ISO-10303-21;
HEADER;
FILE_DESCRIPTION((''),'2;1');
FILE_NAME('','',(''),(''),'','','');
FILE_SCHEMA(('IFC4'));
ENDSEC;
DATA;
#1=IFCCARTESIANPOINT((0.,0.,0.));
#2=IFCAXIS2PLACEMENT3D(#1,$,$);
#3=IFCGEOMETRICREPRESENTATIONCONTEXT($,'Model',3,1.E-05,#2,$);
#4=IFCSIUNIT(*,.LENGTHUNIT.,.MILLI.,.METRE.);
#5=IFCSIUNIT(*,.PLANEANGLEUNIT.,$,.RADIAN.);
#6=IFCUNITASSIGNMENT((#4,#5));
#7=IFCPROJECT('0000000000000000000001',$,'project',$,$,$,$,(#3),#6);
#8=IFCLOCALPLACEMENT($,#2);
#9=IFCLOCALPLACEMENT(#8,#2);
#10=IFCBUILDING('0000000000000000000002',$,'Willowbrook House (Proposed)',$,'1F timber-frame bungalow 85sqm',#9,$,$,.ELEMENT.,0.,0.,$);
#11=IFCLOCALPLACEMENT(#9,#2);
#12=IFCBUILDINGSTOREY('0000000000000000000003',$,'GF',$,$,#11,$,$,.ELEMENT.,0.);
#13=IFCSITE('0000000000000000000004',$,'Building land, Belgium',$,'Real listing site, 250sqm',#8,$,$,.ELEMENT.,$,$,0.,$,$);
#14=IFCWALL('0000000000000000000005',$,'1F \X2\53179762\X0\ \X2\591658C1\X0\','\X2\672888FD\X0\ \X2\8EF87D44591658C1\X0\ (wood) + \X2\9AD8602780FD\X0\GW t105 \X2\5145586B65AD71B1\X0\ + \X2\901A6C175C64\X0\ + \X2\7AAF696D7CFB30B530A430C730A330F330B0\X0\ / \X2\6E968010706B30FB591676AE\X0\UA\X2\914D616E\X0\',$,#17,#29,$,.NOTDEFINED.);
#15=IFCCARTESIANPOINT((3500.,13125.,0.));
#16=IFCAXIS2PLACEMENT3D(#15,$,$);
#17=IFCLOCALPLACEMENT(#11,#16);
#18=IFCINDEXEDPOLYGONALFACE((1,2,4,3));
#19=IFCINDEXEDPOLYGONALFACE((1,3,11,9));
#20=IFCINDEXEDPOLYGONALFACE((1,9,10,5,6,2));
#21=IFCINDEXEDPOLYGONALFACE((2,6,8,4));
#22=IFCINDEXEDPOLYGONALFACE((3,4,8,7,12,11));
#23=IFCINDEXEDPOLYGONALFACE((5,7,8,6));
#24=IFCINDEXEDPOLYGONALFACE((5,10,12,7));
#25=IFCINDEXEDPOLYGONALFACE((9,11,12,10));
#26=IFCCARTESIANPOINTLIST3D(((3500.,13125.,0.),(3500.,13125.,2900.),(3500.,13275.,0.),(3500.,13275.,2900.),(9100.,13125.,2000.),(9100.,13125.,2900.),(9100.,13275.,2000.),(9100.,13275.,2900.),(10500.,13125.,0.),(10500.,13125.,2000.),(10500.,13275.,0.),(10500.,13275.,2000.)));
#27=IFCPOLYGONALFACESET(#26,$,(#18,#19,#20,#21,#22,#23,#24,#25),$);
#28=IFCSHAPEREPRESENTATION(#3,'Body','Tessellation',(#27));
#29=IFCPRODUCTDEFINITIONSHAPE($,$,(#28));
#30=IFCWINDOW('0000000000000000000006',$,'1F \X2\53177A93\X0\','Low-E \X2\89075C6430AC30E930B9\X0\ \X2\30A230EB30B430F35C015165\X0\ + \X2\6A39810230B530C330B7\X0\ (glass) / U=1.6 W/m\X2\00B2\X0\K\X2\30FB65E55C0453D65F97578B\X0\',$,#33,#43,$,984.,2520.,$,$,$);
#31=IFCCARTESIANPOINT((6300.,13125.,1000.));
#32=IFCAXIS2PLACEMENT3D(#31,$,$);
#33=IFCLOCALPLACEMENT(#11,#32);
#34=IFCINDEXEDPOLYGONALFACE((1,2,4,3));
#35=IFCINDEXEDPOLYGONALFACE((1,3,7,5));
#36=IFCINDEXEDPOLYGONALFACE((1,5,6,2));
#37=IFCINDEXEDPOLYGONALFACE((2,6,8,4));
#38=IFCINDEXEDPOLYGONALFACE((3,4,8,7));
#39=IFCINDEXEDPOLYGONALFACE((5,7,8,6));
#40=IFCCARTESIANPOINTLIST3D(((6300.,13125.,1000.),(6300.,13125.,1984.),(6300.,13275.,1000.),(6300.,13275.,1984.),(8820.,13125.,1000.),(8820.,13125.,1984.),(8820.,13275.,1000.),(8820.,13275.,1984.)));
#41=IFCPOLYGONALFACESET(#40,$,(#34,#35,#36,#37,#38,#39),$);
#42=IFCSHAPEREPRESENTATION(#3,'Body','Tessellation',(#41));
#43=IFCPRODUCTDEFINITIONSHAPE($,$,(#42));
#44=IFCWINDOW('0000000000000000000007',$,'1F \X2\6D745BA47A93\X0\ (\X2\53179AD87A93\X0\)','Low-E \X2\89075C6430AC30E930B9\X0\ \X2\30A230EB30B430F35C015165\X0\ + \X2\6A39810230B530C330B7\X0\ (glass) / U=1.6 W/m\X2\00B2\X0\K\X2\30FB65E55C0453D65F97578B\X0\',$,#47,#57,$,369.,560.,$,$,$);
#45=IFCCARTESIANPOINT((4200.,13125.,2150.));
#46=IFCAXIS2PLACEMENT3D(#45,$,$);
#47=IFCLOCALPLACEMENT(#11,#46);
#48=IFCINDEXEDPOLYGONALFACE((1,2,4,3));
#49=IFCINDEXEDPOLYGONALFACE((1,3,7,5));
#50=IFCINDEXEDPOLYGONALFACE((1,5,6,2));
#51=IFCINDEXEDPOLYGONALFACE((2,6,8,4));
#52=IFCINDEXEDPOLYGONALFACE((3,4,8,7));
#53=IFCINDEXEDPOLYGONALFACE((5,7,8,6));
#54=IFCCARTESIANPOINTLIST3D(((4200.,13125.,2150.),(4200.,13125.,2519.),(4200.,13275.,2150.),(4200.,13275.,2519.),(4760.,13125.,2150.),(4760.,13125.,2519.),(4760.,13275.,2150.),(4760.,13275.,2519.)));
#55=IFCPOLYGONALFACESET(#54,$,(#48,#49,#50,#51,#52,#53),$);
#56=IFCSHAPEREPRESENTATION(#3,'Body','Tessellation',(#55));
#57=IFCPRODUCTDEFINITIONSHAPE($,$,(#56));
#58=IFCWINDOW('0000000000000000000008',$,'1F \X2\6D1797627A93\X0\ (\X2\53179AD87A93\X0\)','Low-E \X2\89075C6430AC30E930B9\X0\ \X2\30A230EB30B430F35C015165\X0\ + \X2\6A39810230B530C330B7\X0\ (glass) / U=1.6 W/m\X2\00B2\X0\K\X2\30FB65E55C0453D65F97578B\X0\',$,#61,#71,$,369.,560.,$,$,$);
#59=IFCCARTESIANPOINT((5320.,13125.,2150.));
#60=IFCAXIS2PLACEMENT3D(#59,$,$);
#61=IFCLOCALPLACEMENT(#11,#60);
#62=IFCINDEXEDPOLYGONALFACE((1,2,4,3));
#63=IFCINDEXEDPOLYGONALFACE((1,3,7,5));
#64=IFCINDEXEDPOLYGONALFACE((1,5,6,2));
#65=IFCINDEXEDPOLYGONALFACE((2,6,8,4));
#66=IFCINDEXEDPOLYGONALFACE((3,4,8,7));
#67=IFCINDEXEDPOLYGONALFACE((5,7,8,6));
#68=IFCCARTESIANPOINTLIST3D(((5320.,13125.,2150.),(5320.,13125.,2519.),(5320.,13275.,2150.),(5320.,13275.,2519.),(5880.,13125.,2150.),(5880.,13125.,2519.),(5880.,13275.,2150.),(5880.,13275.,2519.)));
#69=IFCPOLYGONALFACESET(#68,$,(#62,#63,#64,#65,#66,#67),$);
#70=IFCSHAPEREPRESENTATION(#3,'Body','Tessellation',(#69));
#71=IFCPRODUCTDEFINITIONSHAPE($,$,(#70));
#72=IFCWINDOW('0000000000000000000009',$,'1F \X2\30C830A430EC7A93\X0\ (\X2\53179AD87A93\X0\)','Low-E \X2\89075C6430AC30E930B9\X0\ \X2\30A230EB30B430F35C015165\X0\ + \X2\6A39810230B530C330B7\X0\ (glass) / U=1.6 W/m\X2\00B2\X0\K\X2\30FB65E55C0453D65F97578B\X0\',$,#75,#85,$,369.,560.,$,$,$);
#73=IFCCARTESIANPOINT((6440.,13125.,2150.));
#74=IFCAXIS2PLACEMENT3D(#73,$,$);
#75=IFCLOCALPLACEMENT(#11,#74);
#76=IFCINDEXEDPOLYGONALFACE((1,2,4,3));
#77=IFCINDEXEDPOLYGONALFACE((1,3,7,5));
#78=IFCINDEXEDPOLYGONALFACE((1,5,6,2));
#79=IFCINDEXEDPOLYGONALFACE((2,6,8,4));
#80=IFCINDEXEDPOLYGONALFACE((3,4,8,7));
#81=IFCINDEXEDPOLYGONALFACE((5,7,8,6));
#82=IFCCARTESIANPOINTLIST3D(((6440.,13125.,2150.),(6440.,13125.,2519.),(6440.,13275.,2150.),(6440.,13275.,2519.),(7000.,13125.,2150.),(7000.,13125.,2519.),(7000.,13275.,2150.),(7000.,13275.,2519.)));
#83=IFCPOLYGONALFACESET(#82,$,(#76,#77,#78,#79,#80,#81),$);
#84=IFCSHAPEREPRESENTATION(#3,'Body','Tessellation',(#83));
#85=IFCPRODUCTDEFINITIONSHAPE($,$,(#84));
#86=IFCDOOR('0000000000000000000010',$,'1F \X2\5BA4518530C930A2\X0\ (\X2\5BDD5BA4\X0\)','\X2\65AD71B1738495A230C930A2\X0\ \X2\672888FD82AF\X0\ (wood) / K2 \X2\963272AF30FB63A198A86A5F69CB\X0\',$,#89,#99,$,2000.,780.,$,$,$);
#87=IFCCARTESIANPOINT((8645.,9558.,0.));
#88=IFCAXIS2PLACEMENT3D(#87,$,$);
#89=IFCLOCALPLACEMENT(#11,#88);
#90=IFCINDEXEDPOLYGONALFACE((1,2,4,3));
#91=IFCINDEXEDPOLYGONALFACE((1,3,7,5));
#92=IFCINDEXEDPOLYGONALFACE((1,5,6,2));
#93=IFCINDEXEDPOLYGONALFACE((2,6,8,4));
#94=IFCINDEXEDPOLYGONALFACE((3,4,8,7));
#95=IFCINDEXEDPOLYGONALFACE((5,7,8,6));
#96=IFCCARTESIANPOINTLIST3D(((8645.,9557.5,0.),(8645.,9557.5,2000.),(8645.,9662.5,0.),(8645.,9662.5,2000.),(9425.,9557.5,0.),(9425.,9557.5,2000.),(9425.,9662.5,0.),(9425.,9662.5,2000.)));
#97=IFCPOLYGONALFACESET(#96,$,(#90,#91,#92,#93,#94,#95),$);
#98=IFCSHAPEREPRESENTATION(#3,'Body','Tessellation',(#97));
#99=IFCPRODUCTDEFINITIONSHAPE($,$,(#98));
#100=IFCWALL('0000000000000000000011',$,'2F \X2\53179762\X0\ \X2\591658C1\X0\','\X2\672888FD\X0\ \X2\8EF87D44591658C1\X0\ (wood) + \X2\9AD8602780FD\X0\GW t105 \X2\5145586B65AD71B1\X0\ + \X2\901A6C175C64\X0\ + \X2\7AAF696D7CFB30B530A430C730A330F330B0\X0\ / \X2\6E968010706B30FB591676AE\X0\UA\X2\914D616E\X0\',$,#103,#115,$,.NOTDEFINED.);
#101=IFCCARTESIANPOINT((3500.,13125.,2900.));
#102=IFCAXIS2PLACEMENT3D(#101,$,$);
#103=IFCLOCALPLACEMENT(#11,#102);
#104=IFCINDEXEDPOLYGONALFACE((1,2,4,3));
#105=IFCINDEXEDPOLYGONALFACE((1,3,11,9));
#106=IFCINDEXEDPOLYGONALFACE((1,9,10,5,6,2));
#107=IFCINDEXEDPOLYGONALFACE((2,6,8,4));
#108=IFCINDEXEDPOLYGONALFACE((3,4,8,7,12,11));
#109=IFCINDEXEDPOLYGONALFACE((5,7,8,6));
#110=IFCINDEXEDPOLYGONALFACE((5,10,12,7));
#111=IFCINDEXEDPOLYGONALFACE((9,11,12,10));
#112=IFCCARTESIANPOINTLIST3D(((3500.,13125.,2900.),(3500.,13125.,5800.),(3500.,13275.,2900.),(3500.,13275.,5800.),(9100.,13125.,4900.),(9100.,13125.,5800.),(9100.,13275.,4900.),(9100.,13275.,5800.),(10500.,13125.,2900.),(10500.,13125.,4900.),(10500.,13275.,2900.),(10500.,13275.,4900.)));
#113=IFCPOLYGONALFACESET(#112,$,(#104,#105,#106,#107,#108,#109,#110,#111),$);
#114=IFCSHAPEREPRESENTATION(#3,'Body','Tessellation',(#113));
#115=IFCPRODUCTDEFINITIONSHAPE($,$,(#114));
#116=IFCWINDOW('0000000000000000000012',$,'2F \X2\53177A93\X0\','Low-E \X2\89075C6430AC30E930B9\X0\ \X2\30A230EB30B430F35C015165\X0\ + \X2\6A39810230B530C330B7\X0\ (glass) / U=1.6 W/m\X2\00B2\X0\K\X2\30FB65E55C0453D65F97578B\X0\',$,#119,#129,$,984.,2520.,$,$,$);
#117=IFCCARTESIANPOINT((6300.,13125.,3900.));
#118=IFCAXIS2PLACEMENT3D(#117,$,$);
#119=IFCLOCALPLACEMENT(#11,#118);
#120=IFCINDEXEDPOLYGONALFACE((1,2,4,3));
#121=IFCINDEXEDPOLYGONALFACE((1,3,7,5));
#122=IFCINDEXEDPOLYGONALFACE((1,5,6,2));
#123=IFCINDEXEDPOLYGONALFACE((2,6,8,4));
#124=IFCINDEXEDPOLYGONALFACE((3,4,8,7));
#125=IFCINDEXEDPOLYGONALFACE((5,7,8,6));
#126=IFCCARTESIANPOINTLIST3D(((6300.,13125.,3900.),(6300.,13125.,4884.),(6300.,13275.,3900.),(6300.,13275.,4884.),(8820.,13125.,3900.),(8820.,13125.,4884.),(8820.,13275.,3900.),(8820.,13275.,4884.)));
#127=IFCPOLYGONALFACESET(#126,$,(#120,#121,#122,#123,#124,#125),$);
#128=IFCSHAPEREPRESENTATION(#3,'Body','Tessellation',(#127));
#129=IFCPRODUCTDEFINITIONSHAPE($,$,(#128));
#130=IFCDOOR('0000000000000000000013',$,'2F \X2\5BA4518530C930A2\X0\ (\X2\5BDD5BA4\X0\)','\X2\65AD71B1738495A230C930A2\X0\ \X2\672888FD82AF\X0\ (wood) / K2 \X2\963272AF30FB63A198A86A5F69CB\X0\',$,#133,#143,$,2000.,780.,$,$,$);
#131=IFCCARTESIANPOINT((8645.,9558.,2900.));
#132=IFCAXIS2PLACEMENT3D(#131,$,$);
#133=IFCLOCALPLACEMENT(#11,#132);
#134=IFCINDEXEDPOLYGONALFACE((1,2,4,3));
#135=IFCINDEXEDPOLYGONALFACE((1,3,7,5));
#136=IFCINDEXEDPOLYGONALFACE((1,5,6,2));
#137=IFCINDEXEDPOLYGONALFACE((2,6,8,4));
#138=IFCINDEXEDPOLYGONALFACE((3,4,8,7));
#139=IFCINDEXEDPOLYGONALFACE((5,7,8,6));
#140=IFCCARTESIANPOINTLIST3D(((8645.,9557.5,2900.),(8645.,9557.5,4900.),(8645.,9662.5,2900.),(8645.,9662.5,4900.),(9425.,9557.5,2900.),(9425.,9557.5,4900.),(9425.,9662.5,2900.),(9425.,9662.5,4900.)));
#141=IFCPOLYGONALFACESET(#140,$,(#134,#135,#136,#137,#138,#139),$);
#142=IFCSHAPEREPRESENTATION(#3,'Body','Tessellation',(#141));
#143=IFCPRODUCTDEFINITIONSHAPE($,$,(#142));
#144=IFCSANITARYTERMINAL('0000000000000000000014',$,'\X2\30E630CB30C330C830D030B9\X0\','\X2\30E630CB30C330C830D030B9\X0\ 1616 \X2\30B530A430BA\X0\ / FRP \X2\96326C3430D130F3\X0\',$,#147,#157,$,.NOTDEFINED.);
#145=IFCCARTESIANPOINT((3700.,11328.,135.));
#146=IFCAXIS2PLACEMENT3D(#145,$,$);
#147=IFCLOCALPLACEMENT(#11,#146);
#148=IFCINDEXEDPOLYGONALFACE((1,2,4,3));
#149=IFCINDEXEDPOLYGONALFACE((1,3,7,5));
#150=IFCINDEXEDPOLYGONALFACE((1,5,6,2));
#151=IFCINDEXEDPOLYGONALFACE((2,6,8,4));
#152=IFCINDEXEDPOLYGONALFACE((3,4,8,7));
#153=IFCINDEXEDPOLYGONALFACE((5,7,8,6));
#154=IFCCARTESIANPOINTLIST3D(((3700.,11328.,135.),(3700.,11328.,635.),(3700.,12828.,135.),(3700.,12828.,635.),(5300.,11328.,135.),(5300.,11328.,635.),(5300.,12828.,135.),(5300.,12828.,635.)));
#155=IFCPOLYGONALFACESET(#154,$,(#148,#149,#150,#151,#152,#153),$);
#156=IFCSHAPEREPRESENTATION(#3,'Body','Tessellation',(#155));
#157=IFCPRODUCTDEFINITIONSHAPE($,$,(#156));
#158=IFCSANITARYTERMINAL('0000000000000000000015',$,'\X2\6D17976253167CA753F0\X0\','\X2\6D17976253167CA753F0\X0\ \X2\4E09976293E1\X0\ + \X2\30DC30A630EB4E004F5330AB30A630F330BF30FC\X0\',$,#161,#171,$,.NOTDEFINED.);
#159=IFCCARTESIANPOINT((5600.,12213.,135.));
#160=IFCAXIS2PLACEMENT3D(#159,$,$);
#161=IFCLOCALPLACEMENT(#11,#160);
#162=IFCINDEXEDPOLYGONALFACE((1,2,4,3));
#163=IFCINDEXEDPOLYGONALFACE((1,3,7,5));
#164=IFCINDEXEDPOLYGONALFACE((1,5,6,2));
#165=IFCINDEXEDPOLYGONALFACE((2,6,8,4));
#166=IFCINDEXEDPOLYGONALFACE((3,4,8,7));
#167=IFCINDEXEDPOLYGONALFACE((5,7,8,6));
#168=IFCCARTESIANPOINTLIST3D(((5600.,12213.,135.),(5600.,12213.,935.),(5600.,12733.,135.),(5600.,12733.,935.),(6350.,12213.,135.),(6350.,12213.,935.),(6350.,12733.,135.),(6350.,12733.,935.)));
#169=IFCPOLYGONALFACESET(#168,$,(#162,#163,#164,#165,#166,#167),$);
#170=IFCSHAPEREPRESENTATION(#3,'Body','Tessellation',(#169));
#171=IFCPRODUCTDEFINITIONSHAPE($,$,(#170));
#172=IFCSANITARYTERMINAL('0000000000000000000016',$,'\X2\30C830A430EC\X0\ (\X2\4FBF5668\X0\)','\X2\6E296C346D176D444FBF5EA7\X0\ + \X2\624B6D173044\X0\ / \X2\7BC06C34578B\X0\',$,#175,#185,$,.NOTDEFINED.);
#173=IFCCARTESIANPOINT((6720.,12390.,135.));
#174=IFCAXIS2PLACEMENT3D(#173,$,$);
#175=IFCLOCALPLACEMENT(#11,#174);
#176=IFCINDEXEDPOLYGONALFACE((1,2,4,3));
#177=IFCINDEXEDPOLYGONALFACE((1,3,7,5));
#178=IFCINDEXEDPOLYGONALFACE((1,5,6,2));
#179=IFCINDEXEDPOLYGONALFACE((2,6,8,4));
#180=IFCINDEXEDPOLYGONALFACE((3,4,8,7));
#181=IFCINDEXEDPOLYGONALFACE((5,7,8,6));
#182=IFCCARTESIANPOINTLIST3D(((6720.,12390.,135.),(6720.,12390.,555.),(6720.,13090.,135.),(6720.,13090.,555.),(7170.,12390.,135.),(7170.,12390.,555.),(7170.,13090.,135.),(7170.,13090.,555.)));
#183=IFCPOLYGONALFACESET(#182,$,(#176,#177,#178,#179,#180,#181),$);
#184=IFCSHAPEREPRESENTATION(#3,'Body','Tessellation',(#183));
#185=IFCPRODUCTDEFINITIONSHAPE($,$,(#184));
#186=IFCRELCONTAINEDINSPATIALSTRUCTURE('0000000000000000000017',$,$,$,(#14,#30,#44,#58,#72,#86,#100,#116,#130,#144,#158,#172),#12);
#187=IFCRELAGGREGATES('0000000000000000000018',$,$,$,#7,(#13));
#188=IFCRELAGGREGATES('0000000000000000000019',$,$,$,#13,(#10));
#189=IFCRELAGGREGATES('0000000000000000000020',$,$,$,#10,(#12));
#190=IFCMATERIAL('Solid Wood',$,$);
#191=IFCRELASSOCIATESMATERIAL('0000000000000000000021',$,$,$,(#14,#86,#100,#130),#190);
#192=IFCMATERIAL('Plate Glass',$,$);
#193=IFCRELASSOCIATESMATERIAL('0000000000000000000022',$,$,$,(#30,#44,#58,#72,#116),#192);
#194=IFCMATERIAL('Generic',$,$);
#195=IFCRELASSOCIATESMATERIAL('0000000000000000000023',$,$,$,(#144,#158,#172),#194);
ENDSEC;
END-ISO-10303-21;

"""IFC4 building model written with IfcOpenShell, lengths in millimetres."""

from ifc_helpers import new_model, si_unit, frame, frame_2d, origin, place, context, project, spatial, rectangle, extrude, material, element, fill, save


model = new_model("IFC4")

# Units and contexts
model_context = context("Model", 3, precision=1e-05, world=origin())
ifc_project = project(units=[si_unit("LENGTHUNIT", "METRE", prefix="MILLI"), si_unit("PLANEANGLEUNIT", "RADIAN")], contexts=[model_context])

# Site, building, storey
site_placement = place(None, origin())
site = spatial("IfcSite", under=ifc_project, at=site_placement, Name="Building land, Belgium", ObjectType="Real listing site, 250sqm", CompositionType="ELEMENT", RefElevation=0.0)
building_placement = place(site_placement, origin())
building = spatial("IfcBuilding", under=site, at=building_placement, Name="Willowbrook House (Proposed)", ObjectType="1F timber-frame bungalow 85sqm", CompositionType="ELEMENT", ElevationOfRefHeight=0.0, ElevationOfTerrain=0.0)
storey_placement = place(building_placement, origin())
storey = spatial("IfcBuildingStorey", under=building, at=storey_placement, Name="GF", CompositionType="ELEMENT", Elevation=0.0)

# Wall, openings, windows
ifc_material_1 = material(Name="Solid Wood")
wall_1_placement = place(storey_placement, frame((3500.0, 13125.0, 0.0)))
wall_1 = element("IfcWall", 1, at=wall_1_placement, inside=storey, material=ifc_material_1, Name="1F 北面 外壁", Description="木製 軸組外壁 (wood) + 高性能GW t105 充填断熱 + 通気層 + 窯業系サイディング / 準耐火・外皮UA配慮", PredefinedType="NOTDEFINED", context=model_context, shape_type="SweptSolid", body=[
    extrude(rectangle(XDim=7000.0, YDim=150.0, at=frame_2d((3500.0, 75.0))), frame((3500.0, 13125.0, 0.0)), (0.0, 0.0, 1.0), 2900.0),
])
opening_1_placement = place(storey_placement, frame((6300.0, 13125.0, 1000.0)))
opening_1 = element("IfcOpeningElement", 2, at=opening_1_placement, cuts=wall_1, PredefinedType="NOTDEFINED", context=model_context, shape_type="SweptSolid", body=[
    extrude(rectangle(XDim=2520.0, YDim=150.0, at=frame_2d((1260.0, 75.0))), frame((6300.0, 13125.0, 1000.0)), (0.0, 0.0, 1.0), 984.0),
])
opening_2_placement = place(storey_placement, frame((4200.0, 13125.0, 2150.0)))
opening_2 = element("IfcOpeningElement", 3, at=opening_2_placement, cuts=wall_1, PredefinedType="NOTDEFINED", context=model_context, shape_type="SweptSolid", body=[
    extrude(rectangle(XDim=560.0, YDim=150.0, at=frame_2d((280.0, 75.0))), frame((4200.0, 13125.0, 2150.0)), (0.0, 0.0, 1.0), 369.0),
])
opening_3_placement = place(storey_placement, frame((5320.0, 13125.0, 2150.0)))
opening_3 = element("IfcOpeningElement", 4, at=opening_3_placement, cuts=wall_1, PredefinedType="NOTDEFINED", context=model_context, shape_type="SweptSolid", body=[
    extrude(rectangle(XDim=560.0, YDim=150.0, at=frame_2d((280.0, 75.0))), frame((5320.0, 13125.0, 2150.0)), (0.0, 0.0, 1.0), 369.0),
])
opening_4_placement = place(storey_placement, frame((6440.0, 13125.0, 2150.0)))
opening_4 = element("IfcOpeningElement", 5, at=opening_4_placement, cuts=wall_1, PredefinedType="NOTDEFINED", context=model_context, shape_type="SweptSolid", body=[
    extrude(rectangle(XDim=560.0, YDim=150.0, at=frame_2d((280.0, 75.0))), frame((6440.0, 13125.0, 2150.0)), (0.0, 0.0, 1.0), 369.0),
])
ifc_material_2 = material(Name="Plate Glass")
window_1_placement = place(storey_placement, frame((6300.0, 13125.0, 1000.0)))
window_1 = element("IfcWindow", 6, at=window_1_placement, inside=storey, material=ifc_material_2, Name="1F 北窓", Description="Low-E 複層ガラス アルゴン封入 + 樹脂サッシ (glass) / U=1.6 W/m²K・日射取得型", OverallHeight=984.0, OverallWidth=2520.0, context=model_context, shape_type="SweptSolid", body=[
    extrude(rectangle(XDim=2520.0, YDim=150.0, at=frame_2d((1260.0, 75.0))), frame((6300.0, 13125.0, 1000.0)), (0.0, 0.0, 1.0), 984.0),
])
fill(opening_1, window_1)
window_2_placement = place(storey_placement, frame((4200.0, 13125.0, 2150.0)))
window_2 = element("IfcWindow", 7, at=window_2_placement, inside=storey, material=ifc_material_2, Name="1F 浴室窓 (北高窓)", Description="Low-E 複層ガラス アルゴン封入 + 樹脂サッシ (glass) / U=1.6 W/m²K・日射取得型", OverallHeight=369.0, OverallWidth=560.0, context=model_context, shape_type="SweptSolid", body=[
    extrude(rectangle(XDim=560.0, YDim=150.0, at=frame_2d((280.0, 75.0))), frame((4200.0, 13125.0, 2150.0)), (0.0, 0.0, 1.0), 369.0),
])
fill(opening_2, window_2)
window_3_placement = place(storey_placement, frame((5320.0, 13125.0, 2150.0)))
window_3 = element("IfcWindow", 8, at=window_3_placement, inside=storey, material=ifc_material_2, Name="1F 洗面窓 (北高窓)", Description="Low-E 複層ガラス アルゴン封入 + 樹脂サッシ (glass) / U=1.6 W/m²K・日射取得型", OverallHeight=369.0, OverallWidth=560.0, context=model_context, shape_type="SweptSolid", body=[
    extrude(rectangle(XDim=560.0, YDim=150.0, at=frame_2d((280.0, 75.0))), frame((5320.0, 13125.0, 2150.0)), (0.0, 0.0, 1.0), 369.0),
])
fill(opening_3, window_3)
window_4_placement = place(storey_placement, frame((6440.0, 13125.0, 2150.0)))
window_4 = element("IfcWindow", 9, at=window_4_placement, inside=storey, material=ifc_material_2, Name="1F トイレ窓 (北高窓)", Description="Low-E 複層ガラス アルゴン封入 + 樹脂サッシ (glass) / U=1.6 W/m²K・日射取得型", OverallHeight=369.0, OverallWidth=560.0, context=model_context, shape_type="SweptSolid", body=[
    extrude(rectangle(XDim=560.0, YDim=150.0, at=frame_2d((280.0, 75.0))), frame((6440.0, 13125.0, 2150.0)), (0.0, 0.0, 1.0), 369.0),
])
fill(opening_4, window_4)

# Door
door_1_placement = place(storey_placement, frame((8645.0, 9558.0, 0.0)))
element("IfcDoor", 10, at=door_1_placement, inside=storey, material=ifc_material_1, Name="1F 室内ドア (寝室)", Description="断熱玄関ドア 木製芯 (wood) / K2 防犯・採風機構", OverallHeight=2000.0, OverallWidth=780.0, context=model_context, shape_type="SweptSolid", body=[
    extrude(rectangle(XDim=780.0, YDim=105.0, at=frame_2d((390.0, 52.0))), frame((8645.0, 9558.0, 0.0)), (0.0, 0.0, 1.0), 2000.0),
])

# Wall, opening, window
wall_2_placement = place(storey_placement, frame((3500.0, 13125.0, 2900.0)))
wall_2 = element("IfcWall", 11, at=wall_2_placement, inside=storey, material=ifc_material_1, Name="2F 北面 外壁", Description="木製 軸組外壁 (wood) + 高性能GW t105 充填断熱 + 通気層 + 窯業系サイディング / 準耐火・外皮UA配慮", PredefinedType="NOTDEFINED", context=model_context, shape_type="SweptSolid", body=[
    extrude(rectangle(XDim=7000.0, YDim=150.0, at=frame_2d((3500.0, 75.0))), frame((3500.0, 13125.0, 2900.0)), (0.0, 0.0, 1.0), 2900.0),
])
opening_5_placement = place(storey_placement, frame((6300.0, 13125.0, 3900.0)))
opening_5 = element("IfcOpeningElement", 12, at=opening_5_placement, cuts=wall_2, PredefinedType="NOTDEFINED", context=model_context, shape_type="SweptSolid", body=[
    extrude(rectangle(XDim=2520.0, YDim=150.0, at=frame_2d((1260.0, 75.0))), frame((6300.0, 13125.0, 3900.0)), (0.0, 0.0, 1.0), 984.0),
])
window_5_placement = place(storey_placement, frame((6300.0, 13125.0, 3900.0)))
window_5 = element("IfcWindow", 13, at=window_5_placement, inside=storey, material=ifc_material_2, Name="2F 北窓", Description="Low-E 複層ガラス アルゴン封入 + 樹脂サッシ (glass) / U=1.6 W/m²K・日射取得型", OverallHeight=984.0, OverallWidth=2520.0, context=model_context, shape_type="SweptSolid", body=[
    extrude(rectangle(XDim=2520.0, YDim=150.0, at=frame_2d((1260.0, 75.0))), frame((6300.0, 13125.0, 3900.0)), (0.0, 0.0, 1.0), 984.0),
])
fill(opening_5, window_5)

# Door
door_2_placement = place(storey_placement, frame((8645.0, 9558.0, 2900.0)))
element("IfcDoor", 14, at=door_2_placement, inside=storey, material=ifc_material_1, Name="2F 室内ドア (寝室)", Description="断熱玄関ドア 木製芯 (wood) / K2 防犯・採風機構", OverallHeight=2000.0, OverallWidth=780.0, context=model_context, shape_type="SweptSolid", body=[
    extrude(rectangle(XDim=780.0, YDim=105.0, at=frame_2d((390.0, 52.0))), frame((8645.0, 9558.0, 2900.0)), (0.0, 0.0, 1.0), 2000.0),
])

# Sanitary terminals
ifc_material_3 = material(Name="Generic")
sanitary_terminal_1_placement = place(storey_placement, frame((3700.0, 11328.0, 135.0)))
element("IfcSanitaryTerminal", 15, at=sanitary_terminal_1_placement, inside=storey, material=ifc_material_3, Name="ユニットバス", Description="ユニットバス 1616 サイズ / FRP 防水パン", PredefinedType="NOTDEFINED", context=model_context, shape_type="SweptSolid", body=[
    extrude(rectangle(XDim=1600.0, YDim=1500.0, at=frame_2d((800.0, 750.0))), frame((3700.0, 11328.0, 135.0)), (0.0, 0.0, 1.0), 500.0),
])
sanitary_terminal_2_placement = place(storey_placement, frame((5600.0, 12213.0, 135.0)))
element("IfcSanitaryTerminal", 16, at=sanitary_terminal_2_placement, inside=storey, material=ifc_material_3, Name="洗面化粧台", Description="洗面化粧台 三面鏡 + ボウル一体カウンター", PredefinedType="NOTDEFINED", context=model_context, shape_type="SweptSolid", body=[
    extrude(rectangle(XDim=750.0, YDim=520.0, at=frame_2d((375.0, 260.0))), frame((5600.0, 12213.0, 135.0)), (0.0, 0.0, 1.0), 800.0),
])
sanitary_terminal_3_placement = place(storey_placement, frame((6720.0, 12390.0, 135.0)))
element("IfcSanitaryTerminal", 17, at=sanitary_terminal_3_placement, inside=storey, material=ifc_material_3, Name="トイレ (便器)", Description="温水洗浄便座 + 手洗い / 節水型", PredefinedType="NOTDEFINED", context=model_context, shape_type="SweptSolid", body=[
    extrude(rectangle(XDim=450.0, YDim=700.0, at=frame_2d((225.0, 350.0))), frame((6720.0, 12390.0, 135.0)), (0.0, 0.0, 1.0), 420.0),
])

save(model, "model.ifc")
